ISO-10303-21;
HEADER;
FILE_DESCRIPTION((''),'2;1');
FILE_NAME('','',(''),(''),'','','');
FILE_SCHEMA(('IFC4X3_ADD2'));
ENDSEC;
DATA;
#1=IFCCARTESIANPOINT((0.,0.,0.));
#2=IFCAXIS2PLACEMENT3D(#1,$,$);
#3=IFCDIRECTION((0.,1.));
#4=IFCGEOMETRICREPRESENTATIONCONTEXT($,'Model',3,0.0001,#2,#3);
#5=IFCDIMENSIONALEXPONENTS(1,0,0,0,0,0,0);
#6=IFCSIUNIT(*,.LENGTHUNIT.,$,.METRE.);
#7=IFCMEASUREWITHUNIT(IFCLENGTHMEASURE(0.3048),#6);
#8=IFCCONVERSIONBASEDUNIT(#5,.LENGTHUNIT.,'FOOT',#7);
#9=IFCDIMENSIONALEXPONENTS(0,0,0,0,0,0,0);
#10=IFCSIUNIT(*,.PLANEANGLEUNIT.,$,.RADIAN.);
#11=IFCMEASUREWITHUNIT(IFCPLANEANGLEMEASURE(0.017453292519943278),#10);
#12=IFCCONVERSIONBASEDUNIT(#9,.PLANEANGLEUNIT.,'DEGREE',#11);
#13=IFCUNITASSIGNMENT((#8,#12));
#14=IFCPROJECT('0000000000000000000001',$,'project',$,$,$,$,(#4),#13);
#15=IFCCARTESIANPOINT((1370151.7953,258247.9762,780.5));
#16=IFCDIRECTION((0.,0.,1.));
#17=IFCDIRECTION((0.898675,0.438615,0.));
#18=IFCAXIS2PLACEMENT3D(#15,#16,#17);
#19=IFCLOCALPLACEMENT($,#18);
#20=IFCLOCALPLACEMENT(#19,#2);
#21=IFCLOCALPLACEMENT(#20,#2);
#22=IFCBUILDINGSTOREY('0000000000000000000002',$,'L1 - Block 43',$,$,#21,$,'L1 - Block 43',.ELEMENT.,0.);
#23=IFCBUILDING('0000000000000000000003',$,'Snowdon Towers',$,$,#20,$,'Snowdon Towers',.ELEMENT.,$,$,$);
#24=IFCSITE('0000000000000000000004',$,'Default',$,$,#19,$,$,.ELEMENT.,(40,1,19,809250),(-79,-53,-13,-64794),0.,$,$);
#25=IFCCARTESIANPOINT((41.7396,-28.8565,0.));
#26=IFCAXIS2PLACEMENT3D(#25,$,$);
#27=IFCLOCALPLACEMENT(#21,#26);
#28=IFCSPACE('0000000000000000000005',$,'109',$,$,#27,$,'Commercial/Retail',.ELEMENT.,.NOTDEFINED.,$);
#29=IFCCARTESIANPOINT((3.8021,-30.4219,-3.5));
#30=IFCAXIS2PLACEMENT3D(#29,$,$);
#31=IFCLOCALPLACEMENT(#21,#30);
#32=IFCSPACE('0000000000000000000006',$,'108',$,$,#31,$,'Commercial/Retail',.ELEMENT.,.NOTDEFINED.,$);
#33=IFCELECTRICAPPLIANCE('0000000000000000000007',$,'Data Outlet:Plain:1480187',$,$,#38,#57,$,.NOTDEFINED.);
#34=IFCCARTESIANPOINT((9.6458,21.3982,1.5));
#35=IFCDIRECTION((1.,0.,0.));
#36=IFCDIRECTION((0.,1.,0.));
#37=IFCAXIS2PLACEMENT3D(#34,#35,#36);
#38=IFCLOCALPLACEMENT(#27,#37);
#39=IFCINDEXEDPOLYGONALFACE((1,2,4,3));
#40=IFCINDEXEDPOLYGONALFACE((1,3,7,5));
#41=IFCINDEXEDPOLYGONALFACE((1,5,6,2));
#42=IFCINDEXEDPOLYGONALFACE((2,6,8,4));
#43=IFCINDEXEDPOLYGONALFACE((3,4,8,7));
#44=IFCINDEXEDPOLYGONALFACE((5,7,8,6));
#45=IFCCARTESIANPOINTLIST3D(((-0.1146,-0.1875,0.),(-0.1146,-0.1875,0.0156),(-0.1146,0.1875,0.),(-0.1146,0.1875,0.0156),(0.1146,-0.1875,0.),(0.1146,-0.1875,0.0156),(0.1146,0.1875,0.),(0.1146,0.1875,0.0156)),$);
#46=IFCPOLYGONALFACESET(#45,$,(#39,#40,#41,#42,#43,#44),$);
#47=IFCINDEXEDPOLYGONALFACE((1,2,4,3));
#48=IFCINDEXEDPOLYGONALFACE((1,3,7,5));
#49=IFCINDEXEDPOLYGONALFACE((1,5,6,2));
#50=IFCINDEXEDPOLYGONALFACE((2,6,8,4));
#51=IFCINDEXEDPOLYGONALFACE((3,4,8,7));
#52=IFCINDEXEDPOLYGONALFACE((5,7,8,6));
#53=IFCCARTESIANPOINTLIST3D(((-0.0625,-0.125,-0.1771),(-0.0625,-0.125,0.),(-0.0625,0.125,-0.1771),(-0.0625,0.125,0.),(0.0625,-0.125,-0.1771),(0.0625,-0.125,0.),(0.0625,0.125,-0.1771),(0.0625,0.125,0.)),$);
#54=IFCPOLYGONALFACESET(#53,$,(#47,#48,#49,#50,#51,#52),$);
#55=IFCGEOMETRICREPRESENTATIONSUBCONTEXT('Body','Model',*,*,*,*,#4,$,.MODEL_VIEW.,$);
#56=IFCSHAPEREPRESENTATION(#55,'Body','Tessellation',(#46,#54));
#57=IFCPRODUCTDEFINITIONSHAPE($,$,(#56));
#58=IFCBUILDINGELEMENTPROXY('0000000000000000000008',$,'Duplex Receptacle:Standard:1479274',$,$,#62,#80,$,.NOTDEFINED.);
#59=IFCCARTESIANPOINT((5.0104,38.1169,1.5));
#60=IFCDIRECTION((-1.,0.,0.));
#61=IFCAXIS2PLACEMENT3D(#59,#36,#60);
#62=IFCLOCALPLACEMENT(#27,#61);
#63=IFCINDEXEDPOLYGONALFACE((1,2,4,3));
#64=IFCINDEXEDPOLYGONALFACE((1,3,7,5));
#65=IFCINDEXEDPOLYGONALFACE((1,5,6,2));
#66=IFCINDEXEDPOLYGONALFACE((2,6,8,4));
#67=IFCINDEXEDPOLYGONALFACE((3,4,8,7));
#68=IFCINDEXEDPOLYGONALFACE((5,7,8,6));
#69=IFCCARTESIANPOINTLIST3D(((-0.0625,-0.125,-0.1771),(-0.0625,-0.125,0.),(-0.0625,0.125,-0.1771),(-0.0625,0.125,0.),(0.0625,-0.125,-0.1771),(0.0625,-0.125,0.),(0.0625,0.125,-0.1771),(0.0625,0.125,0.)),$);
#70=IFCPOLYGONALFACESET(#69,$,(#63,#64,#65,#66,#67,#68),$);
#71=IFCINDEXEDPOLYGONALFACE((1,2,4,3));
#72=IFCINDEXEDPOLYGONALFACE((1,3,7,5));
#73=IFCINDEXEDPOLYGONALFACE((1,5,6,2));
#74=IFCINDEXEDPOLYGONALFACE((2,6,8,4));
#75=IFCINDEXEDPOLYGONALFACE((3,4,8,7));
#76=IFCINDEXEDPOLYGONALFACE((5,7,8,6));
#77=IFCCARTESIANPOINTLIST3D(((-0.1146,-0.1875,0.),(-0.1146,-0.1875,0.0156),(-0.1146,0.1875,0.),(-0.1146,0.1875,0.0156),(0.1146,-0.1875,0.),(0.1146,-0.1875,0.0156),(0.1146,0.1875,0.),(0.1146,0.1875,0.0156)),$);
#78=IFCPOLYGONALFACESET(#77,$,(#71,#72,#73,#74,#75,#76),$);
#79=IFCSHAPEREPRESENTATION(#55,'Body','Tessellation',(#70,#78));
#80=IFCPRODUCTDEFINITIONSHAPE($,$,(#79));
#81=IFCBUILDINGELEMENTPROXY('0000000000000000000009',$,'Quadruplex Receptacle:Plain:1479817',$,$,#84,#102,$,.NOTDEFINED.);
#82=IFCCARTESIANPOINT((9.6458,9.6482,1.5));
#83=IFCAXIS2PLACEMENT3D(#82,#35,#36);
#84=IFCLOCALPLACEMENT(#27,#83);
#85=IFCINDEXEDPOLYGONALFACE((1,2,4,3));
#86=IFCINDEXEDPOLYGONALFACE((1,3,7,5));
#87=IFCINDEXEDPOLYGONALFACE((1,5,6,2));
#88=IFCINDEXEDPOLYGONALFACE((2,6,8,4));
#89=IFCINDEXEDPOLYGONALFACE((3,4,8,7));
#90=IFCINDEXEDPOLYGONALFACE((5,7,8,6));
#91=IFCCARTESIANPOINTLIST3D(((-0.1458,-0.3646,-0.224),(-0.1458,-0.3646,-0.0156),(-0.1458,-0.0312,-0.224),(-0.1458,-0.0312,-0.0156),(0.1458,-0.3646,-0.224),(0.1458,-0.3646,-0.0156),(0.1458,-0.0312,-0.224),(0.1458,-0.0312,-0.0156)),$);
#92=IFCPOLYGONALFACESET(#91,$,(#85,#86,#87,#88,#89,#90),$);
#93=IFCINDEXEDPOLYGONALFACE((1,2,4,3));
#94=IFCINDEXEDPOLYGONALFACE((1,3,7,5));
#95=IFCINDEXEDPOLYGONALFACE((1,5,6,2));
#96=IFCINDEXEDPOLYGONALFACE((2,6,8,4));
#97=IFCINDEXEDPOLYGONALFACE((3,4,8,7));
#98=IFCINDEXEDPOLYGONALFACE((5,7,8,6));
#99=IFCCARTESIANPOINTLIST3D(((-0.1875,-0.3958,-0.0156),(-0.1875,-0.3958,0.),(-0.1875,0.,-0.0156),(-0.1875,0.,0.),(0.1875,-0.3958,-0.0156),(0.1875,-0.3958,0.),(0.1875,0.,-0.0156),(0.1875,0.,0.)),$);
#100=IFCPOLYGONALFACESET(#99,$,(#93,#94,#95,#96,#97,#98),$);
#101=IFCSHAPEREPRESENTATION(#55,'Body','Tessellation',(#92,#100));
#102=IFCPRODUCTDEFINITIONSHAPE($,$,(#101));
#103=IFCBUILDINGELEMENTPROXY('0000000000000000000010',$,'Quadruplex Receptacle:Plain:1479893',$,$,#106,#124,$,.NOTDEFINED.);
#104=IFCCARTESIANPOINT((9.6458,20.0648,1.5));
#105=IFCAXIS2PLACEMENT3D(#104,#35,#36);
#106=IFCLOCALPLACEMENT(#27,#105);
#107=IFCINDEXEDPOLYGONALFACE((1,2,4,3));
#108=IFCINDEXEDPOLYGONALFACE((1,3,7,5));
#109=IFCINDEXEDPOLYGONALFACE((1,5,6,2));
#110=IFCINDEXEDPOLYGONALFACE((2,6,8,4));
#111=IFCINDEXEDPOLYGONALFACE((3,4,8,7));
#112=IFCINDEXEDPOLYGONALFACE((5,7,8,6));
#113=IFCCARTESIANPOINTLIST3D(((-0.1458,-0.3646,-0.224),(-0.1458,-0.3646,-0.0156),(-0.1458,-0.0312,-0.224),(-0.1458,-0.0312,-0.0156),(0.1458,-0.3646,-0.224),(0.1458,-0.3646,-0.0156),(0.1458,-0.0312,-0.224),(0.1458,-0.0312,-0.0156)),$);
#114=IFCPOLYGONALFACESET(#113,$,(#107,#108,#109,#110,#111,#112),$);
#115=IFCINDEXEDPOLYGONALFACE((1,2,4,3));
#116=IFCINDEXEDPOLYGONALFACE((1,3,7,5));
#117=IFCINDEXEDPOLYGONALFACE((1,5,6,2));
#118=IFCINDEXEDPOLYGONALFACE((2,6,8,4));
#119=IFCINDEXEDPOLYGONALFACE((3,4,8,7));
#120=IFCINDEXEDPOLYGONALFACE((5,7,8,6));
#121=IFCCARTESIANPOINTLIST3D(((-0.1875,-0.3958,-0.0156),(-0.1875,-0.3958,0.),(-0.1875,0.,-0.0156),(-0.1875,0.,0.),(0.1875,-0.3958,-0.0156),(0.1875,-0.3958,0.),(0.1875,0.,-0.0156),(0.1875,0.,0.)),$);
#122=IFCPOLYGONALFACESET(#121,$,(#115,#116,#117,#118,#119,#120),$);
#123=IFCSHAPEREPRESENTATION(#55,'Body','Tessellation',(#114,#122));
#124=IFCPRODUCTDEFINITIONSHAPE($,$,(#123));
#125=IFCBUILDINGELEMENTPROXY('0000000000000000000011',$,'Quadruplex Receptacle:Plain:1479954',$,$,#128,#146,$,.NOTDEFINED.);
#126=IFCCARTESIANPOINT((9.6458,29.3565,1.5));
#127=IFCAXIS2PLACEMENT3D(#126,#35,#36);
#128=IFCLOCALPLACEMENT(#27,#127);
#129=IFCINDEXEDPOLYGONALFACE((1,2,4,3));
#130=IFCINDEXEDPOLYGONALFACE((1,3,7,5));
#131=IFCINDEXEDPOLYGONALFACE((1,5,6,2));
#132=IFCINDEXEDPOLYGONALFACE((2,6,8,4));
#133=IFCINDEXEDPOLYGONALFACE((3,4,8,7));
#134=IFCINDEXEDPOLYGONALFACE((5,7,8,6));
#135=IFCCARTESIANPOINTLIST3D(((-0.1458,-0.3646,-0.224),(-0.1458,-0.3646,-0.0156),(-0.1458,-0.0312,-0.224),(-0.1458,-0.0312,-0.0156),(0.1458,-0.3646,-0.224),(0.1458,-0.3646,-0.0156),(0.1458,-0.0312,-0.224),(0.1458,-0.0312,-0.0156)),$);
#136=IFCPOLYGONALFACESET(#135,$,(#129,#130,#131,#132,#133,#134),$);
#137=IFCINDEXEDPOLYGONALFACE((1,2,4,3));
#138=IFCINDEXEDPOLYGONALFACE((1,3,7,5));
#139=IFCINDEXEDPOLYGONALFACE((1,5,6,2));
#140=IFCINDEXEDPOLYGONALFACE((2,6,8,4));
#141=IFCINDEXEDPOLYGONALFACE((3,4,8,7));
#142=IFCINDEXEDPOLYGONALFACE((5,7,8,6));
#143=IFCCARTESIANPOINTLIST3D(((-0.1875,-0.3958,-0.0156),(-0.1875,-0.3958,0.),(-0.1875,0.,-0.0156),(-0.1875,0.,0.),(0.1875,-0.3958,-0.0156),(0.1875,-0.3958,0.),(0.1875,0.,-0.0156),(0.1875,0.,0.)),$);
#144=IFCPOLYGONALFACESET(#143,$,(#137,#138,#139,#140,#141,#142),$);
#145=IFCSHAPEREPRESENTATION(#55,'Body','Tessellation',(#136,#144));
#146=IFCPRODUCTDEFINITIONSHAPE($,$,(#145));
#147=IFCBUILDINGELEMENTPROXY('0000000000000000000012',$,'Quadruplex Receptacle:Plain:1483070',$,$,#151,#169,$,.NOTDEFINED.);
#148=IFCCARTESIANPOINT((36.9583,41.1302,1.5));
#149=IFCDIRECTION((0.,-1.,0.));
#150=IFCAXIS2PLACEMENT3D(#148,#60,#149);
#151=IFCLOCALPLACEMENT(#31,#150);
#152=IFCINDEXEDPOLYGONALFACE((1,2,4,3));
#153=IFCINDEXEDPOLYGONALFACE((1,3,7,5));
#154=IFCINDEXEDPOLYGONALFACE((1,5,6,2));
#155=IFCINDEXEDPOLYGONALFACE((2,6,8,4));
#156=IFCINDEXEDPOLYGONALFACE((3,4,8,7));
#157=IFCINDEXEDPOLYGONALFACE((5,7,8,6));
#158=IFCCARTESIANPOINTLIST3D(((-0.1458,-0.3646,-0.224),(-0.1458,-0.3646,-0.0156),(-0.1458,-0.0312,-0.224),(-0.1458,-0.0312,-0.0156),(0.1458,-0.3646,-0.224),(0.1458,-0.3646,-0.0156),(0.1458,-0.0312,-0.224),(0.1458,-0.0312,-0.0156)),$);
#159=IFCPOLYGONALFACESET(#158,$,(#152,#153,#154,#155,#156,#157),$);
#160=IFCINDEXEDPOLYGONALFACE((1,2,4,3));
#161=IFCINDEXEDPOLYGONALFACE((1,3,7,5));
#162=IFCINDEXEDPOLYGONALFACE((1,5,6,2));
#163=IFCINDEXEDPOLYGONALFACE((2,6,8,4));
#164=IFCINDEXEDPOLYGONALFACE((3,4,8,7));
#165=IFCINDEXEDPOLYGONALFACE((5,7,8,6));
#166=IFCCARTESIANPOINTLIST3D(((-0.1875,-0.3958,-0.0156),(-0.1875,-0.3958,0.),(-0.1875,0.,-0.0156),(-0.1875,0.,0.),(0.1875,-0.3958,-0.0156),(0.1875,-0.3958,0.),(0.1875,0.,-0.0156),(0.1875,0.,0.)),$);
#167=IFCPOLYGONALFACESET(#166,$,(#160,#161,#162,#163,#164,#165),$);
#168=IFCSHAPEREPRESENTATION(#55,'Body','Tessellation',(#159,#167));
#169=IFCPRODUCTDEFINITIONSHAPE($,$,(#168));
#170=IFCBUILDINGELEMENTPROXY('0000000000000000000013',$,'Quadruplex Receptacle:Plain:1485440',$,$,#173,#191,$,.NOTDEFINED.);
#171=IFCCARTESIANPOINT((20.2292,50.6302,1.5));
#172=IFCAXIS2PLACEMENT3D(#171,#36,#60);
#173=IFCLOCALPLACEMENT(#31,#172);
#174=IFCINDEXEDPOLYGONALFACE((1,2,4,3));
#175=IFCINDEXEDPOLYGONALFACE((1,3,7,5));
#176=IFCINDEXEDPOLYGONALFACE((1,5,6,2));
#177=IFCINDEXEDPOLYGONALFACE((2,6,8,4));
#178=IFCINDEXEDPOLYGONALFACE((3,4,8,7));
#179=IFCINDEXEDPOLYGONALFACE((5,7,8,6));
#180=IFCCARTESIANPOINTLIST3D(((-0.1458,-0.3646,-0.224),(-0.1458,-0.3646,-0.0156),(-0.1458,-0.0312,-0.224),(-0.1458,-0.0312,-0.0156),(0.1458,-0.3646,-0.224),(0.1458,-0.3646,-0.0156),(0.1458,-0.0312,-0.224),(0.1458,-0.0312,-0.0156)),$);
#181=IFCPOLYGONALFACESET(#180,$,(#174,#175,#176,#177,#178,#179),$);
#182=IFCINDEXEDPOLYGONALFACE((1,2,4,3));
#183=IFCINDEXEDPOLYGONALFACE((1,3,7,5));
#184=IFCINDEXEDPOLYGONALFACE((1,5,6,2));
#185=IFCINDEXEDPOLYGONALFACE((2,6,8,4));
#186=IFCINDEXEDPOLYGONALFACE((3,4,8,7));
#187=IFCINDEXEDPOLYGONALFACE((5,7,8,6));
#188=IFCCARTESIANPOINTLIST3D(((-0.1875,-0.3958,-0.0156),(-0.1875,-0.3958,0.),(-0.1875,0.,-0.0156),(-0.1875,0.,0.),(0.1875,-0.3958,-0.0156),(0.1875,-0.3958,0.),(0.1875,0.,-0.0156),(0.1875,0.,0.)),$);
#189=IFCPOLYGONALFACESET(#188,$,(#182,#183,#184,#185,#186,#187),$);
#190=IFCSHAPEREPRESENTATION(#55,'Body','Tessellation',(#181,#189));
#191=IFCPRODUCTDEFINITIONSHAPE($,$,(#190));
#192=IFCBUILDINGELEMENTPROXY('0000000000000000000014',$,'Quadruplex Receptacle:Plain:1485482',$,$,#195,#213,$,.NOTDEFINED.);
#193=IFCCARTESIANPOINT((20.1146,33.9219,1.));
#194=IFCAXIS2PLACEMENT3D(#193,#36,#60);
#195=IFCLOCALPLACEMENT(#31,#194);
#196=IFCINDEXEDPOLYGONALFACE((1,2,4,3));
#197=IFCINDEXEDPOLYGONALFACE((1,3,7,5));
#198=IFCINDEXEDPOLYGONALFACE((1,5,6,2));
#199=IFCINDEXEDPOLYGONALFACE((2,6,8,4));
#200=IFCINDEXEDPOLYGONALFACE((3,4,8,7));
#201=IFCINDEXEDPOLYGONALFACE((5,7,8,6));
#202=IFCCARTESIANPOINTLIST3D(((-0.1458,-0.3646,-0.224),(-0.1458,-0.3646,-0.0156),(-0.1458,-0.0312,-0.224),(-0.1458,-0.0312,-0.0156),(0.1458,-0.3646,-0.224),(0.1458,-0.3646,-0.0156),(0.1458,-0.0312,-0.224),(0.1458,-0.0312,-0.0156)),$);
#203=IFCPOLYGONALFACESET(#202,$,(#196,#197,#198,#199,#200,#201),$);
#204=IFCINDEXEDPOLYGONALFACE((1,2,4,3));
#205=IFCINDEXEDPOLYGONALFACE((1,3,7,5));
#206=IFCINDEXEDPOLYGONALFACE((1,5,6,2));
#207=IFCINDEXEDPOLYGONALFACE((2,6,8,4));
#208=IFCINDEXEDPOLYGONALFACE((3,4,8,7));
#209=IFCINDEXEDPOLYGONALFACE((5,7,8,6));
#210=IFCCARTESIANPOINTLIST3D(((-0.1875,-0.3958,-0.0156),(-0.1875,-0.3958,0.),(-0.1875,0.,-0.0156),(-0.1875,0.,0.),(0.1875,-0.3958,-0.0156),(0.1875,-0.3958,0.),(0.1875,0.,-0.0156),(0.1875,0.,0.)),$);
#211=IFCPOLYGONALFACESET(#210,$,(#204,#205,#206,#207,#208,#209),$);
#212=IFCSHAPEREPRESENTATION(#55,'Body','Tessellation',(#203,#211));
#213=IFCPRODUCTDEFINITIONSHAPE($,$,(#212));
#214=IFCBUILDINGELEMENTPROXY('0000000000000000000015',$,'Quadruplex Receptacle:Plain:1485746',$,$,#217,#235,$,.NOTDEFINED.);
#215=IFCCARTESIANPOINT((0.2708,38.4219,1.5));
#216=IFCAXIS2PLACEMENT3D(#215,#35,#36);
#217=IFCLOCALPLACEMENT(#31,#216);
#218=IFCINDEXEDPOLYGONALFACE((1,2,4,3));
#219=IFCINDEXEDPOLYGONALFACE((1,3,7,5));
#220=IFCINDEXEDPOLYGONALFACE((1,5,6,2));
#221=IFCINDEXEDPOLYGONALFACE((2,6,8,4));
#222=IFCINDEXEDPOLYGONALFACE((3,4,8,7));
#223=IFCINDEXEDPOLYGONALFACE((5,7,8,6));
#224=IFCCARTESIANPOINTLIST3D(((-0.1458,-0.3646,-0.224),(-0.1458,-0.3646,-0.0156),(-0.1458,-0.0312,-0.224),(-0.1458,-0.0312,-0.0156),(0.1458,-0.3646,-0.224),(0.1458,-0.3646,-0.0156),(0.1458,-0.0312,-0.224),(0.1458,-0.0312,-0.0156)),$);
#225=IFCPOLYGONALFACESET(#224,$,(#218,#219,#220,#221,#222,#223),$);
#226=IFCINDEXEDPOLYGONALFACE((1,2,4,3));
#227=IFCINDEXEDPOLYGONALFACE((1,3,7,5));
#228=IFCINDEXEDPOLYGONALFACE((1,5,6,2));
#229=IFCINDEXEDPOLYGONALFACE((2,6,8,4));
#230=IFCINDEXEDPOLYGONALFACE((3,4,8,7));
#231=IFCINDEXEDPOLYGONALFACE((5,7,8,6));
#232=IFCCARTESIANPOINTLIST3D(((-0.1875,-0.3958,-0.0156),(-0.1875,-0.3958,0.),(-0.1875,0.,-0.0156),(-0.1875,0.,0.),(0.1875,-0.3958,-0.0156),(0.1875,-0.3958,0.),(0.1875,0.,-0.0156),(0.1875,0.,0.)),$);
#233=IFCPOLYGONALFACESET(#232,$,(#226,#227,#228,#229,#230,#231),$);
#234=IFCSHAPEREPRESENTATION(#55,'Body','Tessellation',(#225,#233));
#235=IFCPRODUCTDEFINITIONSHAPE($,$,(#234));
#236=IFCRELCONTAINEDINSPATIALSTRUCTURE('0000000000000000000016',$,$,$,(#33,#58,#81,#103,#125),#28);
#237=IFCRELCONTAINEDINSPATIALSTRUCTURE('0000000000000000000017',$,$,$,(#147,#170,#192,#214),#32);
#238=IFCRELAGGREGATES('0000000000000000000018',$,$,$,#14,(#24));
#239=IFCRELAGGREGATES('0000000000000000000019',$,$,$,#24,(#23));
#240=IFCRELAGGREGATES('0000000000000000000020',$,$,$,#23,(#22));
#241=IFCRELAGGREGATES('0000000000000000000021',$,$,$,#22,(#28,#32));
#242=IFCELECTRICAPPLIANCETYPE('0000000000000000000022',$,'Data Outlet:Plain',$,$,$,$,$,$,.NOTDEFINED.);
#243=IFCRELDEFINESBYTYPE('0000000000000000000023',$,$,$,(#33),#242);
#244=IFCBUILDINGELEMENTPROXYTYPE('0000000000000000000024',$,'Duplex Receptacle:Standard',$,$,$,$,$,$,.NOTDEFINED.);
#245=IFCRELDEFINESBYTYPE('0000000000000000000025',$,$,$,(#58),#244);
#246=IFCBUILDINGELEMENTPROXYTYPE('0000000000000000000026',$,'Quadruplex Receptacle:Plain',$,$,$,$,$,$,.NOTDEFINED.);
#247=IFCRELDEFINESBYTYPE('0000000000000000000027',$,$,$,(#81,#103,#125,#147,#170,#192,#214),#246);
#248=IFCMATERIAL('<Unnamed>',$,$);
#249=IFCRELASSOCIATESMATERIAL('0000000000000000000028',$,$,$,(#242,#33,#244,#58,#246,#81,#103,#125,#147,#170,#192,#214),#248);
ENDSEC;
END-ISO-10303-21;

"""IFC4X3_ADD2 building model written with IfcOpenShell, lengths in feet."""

from ifc_helpers import new_model, entity, si_unit, converted_unit, direction, frame, frame_2d, origin, origin_2d_with_axis, place, context, subcontext, project, spatial, rectangle, extrude, source, transform, mapped, material, type_object, type_shapes, element, save


model = new_model("IFC4X3_ADD2")

# Units and contexts
model_context = context("Model", 3, precision=0.0001, world=origin(), true_north=direction((0.0, 1.0)))
body_context = subcontext(model_context, "Body", "Model", "MODEL_VIEW")
ifc_project = project(units=[converted_unit("LENGTHUNIT", "FOOT", entity("IfcLengthMeasure", 0.3048), si_unit("LENGTHUNIT", "METRE"), dimensions=[1, 0, 0, 0, 0, 0, 0]), converted_unit("PLANEANGLEUNIT", "DEGREE", entity("IfcPlaneAngleMeasure", 0.017453292519943278), si_unit("PLANEANGLEUNIT", "RADIAN"), dimensions=[0, 0, 0, 0, 0, 0, 0])], contexts=[model_context])

# Site, building, storey
site_placement = place(None, frame((1370151.7953, 258247.9762, 780.5), z_axis=(0.0, 0.0, 1.0), x_axis=(0.898675, 0.438615, 0.0)))
site = spatial("IfcSite", under=ifc_project, at=site_placement, Name="Default", CompositionType="ELEMENT", RefLatitude=(40, 1, 19, 809250), RefLongitude=(-79, -53, -13, -64794), RefElevation=0.0)
building_placement = place(site_placement, origin())
building = spatial("IfcBuilding", under=site, at=building_placement, Name="Snowdon Towers", LongName="Snowdon Towers", CompositionType="ELEMENT")
storey_placement = place(building_placement, origin())
storey = spatial("IfcBuildingStorey", under=building, at=storey_placement, Name="L1 - Block 43", LongName="L1 - Block 43", CompositionType="ELEMENT", Elevation=0.0)

# Shared definitions
space_1_placement = place(storey_placement, frame((41.7396, -28.8565, 0.0)))
space_1 = spatial("IfcSpace", under=storey, at=space_1_placement, Name="109", LongName="Commercial/Retail", CompositionType="ELEMENT", PredefinedType="NOTDEFINED")

# Electric appliance
ifc_material_1 = material(Name="<Unnamed>")
electric_appliance_type = type_object("IfcElectricApplianceType", Name="Data Outlet:Plain", PredefinedType="NOTDEFINED", material=ifc_material_1)
shared_shape_1 = source(origin(), body_context, "Body", "SweptSolid", [
    extrude(rectangle(XDim=0.2292, YDim=0.375, at=frame_2d((0.0, 0.0), x_axis=(1.0, 0.0))), frame((0.0, 0.0, 0.0), z_axis=(0.0, 0.0, 1.0), x_axis=(-1.0, 0.0, 0.0)), (0.0, 0.0, 1.0), 0.0156),
    extrude(rectangle(XDim=0.125, YDim=0.25, at=frame_2d((0.0, 0.0), x_axis=(1.0, 0.0))), frame((0.0, 0.0, -0.1771), z_axis=(0.0, 0.0, 1.0), x_axis=(-1.0, 0.0, 0.0)), (0.0, 0.0, 1.0), 0.1771),
])
type_shapes(electric_appliance_type, [shared_shape_1])
for number, where, z_axis, x_axis, name in (
    (1, (9.6458, 21.3982, 1.5), (1.0, 0.0, 0.0), (0.0, 1.0, 0.0), "Data Outlet:Plain:1480187"),
):
    element("IfcElectricAppliance", number, at=place(space_1_placement, frame(where, z_axis=z_axis, x_axis=x_axis)), inside=space_1, type_object=electric_appliance_type, material=ifc_material_1, Name=name, PredefinedType="NOTDEFINED", context=body_context, shape_type="MappedRepresentation", body=[
        mapped(shared_shape_1, transform((0.0, 0.0, 0.0), scale=1.0)),
    ])

# Building element proxy
building_element_proxy_type_1 = type_object("IfcBuildingElementProxyType", Name="Duplex Receptacle:Standard", PredefinedType="NOTDEFINED", material=ifc_material_1)
shared_shape_2 = source(origin(), body_context, "Body", "SweptSolid", [
    extrude(rectangle(XDim=0.125, YDim=0.25, at=origin_2d_with_axis()), frame((0.0, 0.0, -0.1771), z_axis=(0.0, 0.0, 1.0), x_axis=(-1.0, 0.0, 0.0)), (0.0, 0.0, 1.0), 0.1771),
    extrude(rectangle(XDim=0.2292, YDim=0.375, at=frame_2d((0.0, 0.0), x_axis=(1.0, 0.0))), frame((0.0, 0.0, 0.0), z_axis=(0.0, 0.0, 1.0), x_axis=(-1.0, 0.0, 0.0)), (0.0, 0.0, 1.0), 0.0156),
])
type_shapes(building_element_proxy_type_1, [shared_shape_2])
proxy_1_placement = place(space_1_placement, frame((5.0104, 38.1169, 1.5), z_axis=(0.0, 1.0, 0.0), x_axis=(-1.0, 0.0, 0.0)))
element("IfcBuildingElementProxy", 2, at=proxy_1_placement, inside=space_1, type_object=building_element_proxy_type_1, material=ifc_material_1, Name="Duplex Receptacle:Standard:1479274", PredefinedType="NOTDEFINED", context=body_context, shape_type="MappedRepresentation", body=[
    mapped(shared_shape_2, transform((0.0, 0.0, 0.0), scale=1.0)),
])

# Shared definitions
space_2_placement = place(storey_placement, frame((3.8021, -30.4219, -3.5)))
space_2 = spatial("IfcSpace", under=storey, at=space_2_placement, Name="108", LongName="Commercial/Retail", CompositionType="ELEMENT", PredefinedType="NOTDEFINED")

# Building element proxies
building_element_proxy_type_2 = type_object("IfcBuildingElementProxyType", Name="Quadruplex Receptacle:Plain", PredefinedType="NOTDEFINED", material=ifc_material_1)
shared_shape_3 = source(origin(), body_context, "Body", "SweptSolid", [
    extrude(rectangle(XDim=0.2917, YDim=0.3333, at=frame_2d((0.0, 0.0), x_axis=(1.0, 0.0))), frame((0.0, -0.1979, -0.224), z_axis=(0.0, 0.0, 1.0), x_axis=(-1.0, 0.0, 0.0)), (0.0, 0.0, 1.0), 0.2083),
    extrude(rectangle(XDim=0.375, YDim=0.3958, at=origin_2d_with_axis()), frame((0.0, -0.1979, -0.0156), z_axis=(0.0, 0.0, 1.0), x_axis=(-1.0, 0.0, 0.0)), (0.0, 0.0, 1.0), 0.0156),
])
type_shapes(building_element_proxy_type_2, [shared_shape_3])
for number, where, z_axis, x_axis, name in (
    (3, (9.6458, 9.6482, 1.5), (1.0, 0.0, 0.0), (0.0, 1.0, 0.0), "Quadruplex Receptacle:Plain:1479817"),
    (4, (9.6458, 20.0648, 1.5), (1.0, 0.0, 0.0), (0.0, 1.0, 0.0), "Quadruplex Receptacle:Plain:1479893"),
    (5, (9.6458, 29.3565, 1.5), (1.0, 0.0, 0.0), (0.0, 1.0, 0.0), "Quadruplex Receptacle:Plain:1479954"),
):
    element("IfcBuildingElementProxy", number, at=place(space_1_placement, frame(where, z_axis=z_axis, x_axis=x_axis)), inside=space_1, type_object=building_element_proxy_type_2, material=ifc_material_1, Name=name, PredefinedType="NOTDEFINED", context=body_context, shape_type="MappedRepresentation", body=[
        mapped(shared_shape_3, transform((0.0, 0.0, 0.0), scale=1.0)),
    ])
for number, where, z_axis, x_axis, name in (
    (6, (36.9583, 41.1302, 1.5), (-1.0, 0.0, 0.0), (0.0, -1.0, 0.0), "Quadruplex Receptacle:Plain:1483070"),
    (7, (20.2292, 50.6302, 1.5), (0.0, 1.0, 0.0), (-1.0, 0.0, 0.0), "Quadruplex Receptacle:Plain:1485440"),
    (8, (20.1146, 33.9219, 1.0), (0.0, 1.0, 0.0), (-1.0, 0.0, 0.0), "Quadruplex Receptacle:Plain:1485482"),
    (9, (0.2708, 38.4219, 1.5), (1.0, 0.0, 0.0), (0.0, 1.0, 0.0), "Quadruplex Receptacle:Plain:1485746"),
):
    element("IfcBuildingElementProxy", number, at=place(space_2_placement, frame(where, z_axis=z_axis, x_axis=x_axis)), inside=space_2, type_object=building_element_proxy_type_2, material=ifc_material_1, Name=name, PredefinedType="NOTDEFINED", context=body_context, shape_type="MappedRepresentation", body=[
        mapped(shared_shape_3, transform((0.0, 0.0, 0.0), scale=1.0)),
    ])

save(model, "model.ifc")
